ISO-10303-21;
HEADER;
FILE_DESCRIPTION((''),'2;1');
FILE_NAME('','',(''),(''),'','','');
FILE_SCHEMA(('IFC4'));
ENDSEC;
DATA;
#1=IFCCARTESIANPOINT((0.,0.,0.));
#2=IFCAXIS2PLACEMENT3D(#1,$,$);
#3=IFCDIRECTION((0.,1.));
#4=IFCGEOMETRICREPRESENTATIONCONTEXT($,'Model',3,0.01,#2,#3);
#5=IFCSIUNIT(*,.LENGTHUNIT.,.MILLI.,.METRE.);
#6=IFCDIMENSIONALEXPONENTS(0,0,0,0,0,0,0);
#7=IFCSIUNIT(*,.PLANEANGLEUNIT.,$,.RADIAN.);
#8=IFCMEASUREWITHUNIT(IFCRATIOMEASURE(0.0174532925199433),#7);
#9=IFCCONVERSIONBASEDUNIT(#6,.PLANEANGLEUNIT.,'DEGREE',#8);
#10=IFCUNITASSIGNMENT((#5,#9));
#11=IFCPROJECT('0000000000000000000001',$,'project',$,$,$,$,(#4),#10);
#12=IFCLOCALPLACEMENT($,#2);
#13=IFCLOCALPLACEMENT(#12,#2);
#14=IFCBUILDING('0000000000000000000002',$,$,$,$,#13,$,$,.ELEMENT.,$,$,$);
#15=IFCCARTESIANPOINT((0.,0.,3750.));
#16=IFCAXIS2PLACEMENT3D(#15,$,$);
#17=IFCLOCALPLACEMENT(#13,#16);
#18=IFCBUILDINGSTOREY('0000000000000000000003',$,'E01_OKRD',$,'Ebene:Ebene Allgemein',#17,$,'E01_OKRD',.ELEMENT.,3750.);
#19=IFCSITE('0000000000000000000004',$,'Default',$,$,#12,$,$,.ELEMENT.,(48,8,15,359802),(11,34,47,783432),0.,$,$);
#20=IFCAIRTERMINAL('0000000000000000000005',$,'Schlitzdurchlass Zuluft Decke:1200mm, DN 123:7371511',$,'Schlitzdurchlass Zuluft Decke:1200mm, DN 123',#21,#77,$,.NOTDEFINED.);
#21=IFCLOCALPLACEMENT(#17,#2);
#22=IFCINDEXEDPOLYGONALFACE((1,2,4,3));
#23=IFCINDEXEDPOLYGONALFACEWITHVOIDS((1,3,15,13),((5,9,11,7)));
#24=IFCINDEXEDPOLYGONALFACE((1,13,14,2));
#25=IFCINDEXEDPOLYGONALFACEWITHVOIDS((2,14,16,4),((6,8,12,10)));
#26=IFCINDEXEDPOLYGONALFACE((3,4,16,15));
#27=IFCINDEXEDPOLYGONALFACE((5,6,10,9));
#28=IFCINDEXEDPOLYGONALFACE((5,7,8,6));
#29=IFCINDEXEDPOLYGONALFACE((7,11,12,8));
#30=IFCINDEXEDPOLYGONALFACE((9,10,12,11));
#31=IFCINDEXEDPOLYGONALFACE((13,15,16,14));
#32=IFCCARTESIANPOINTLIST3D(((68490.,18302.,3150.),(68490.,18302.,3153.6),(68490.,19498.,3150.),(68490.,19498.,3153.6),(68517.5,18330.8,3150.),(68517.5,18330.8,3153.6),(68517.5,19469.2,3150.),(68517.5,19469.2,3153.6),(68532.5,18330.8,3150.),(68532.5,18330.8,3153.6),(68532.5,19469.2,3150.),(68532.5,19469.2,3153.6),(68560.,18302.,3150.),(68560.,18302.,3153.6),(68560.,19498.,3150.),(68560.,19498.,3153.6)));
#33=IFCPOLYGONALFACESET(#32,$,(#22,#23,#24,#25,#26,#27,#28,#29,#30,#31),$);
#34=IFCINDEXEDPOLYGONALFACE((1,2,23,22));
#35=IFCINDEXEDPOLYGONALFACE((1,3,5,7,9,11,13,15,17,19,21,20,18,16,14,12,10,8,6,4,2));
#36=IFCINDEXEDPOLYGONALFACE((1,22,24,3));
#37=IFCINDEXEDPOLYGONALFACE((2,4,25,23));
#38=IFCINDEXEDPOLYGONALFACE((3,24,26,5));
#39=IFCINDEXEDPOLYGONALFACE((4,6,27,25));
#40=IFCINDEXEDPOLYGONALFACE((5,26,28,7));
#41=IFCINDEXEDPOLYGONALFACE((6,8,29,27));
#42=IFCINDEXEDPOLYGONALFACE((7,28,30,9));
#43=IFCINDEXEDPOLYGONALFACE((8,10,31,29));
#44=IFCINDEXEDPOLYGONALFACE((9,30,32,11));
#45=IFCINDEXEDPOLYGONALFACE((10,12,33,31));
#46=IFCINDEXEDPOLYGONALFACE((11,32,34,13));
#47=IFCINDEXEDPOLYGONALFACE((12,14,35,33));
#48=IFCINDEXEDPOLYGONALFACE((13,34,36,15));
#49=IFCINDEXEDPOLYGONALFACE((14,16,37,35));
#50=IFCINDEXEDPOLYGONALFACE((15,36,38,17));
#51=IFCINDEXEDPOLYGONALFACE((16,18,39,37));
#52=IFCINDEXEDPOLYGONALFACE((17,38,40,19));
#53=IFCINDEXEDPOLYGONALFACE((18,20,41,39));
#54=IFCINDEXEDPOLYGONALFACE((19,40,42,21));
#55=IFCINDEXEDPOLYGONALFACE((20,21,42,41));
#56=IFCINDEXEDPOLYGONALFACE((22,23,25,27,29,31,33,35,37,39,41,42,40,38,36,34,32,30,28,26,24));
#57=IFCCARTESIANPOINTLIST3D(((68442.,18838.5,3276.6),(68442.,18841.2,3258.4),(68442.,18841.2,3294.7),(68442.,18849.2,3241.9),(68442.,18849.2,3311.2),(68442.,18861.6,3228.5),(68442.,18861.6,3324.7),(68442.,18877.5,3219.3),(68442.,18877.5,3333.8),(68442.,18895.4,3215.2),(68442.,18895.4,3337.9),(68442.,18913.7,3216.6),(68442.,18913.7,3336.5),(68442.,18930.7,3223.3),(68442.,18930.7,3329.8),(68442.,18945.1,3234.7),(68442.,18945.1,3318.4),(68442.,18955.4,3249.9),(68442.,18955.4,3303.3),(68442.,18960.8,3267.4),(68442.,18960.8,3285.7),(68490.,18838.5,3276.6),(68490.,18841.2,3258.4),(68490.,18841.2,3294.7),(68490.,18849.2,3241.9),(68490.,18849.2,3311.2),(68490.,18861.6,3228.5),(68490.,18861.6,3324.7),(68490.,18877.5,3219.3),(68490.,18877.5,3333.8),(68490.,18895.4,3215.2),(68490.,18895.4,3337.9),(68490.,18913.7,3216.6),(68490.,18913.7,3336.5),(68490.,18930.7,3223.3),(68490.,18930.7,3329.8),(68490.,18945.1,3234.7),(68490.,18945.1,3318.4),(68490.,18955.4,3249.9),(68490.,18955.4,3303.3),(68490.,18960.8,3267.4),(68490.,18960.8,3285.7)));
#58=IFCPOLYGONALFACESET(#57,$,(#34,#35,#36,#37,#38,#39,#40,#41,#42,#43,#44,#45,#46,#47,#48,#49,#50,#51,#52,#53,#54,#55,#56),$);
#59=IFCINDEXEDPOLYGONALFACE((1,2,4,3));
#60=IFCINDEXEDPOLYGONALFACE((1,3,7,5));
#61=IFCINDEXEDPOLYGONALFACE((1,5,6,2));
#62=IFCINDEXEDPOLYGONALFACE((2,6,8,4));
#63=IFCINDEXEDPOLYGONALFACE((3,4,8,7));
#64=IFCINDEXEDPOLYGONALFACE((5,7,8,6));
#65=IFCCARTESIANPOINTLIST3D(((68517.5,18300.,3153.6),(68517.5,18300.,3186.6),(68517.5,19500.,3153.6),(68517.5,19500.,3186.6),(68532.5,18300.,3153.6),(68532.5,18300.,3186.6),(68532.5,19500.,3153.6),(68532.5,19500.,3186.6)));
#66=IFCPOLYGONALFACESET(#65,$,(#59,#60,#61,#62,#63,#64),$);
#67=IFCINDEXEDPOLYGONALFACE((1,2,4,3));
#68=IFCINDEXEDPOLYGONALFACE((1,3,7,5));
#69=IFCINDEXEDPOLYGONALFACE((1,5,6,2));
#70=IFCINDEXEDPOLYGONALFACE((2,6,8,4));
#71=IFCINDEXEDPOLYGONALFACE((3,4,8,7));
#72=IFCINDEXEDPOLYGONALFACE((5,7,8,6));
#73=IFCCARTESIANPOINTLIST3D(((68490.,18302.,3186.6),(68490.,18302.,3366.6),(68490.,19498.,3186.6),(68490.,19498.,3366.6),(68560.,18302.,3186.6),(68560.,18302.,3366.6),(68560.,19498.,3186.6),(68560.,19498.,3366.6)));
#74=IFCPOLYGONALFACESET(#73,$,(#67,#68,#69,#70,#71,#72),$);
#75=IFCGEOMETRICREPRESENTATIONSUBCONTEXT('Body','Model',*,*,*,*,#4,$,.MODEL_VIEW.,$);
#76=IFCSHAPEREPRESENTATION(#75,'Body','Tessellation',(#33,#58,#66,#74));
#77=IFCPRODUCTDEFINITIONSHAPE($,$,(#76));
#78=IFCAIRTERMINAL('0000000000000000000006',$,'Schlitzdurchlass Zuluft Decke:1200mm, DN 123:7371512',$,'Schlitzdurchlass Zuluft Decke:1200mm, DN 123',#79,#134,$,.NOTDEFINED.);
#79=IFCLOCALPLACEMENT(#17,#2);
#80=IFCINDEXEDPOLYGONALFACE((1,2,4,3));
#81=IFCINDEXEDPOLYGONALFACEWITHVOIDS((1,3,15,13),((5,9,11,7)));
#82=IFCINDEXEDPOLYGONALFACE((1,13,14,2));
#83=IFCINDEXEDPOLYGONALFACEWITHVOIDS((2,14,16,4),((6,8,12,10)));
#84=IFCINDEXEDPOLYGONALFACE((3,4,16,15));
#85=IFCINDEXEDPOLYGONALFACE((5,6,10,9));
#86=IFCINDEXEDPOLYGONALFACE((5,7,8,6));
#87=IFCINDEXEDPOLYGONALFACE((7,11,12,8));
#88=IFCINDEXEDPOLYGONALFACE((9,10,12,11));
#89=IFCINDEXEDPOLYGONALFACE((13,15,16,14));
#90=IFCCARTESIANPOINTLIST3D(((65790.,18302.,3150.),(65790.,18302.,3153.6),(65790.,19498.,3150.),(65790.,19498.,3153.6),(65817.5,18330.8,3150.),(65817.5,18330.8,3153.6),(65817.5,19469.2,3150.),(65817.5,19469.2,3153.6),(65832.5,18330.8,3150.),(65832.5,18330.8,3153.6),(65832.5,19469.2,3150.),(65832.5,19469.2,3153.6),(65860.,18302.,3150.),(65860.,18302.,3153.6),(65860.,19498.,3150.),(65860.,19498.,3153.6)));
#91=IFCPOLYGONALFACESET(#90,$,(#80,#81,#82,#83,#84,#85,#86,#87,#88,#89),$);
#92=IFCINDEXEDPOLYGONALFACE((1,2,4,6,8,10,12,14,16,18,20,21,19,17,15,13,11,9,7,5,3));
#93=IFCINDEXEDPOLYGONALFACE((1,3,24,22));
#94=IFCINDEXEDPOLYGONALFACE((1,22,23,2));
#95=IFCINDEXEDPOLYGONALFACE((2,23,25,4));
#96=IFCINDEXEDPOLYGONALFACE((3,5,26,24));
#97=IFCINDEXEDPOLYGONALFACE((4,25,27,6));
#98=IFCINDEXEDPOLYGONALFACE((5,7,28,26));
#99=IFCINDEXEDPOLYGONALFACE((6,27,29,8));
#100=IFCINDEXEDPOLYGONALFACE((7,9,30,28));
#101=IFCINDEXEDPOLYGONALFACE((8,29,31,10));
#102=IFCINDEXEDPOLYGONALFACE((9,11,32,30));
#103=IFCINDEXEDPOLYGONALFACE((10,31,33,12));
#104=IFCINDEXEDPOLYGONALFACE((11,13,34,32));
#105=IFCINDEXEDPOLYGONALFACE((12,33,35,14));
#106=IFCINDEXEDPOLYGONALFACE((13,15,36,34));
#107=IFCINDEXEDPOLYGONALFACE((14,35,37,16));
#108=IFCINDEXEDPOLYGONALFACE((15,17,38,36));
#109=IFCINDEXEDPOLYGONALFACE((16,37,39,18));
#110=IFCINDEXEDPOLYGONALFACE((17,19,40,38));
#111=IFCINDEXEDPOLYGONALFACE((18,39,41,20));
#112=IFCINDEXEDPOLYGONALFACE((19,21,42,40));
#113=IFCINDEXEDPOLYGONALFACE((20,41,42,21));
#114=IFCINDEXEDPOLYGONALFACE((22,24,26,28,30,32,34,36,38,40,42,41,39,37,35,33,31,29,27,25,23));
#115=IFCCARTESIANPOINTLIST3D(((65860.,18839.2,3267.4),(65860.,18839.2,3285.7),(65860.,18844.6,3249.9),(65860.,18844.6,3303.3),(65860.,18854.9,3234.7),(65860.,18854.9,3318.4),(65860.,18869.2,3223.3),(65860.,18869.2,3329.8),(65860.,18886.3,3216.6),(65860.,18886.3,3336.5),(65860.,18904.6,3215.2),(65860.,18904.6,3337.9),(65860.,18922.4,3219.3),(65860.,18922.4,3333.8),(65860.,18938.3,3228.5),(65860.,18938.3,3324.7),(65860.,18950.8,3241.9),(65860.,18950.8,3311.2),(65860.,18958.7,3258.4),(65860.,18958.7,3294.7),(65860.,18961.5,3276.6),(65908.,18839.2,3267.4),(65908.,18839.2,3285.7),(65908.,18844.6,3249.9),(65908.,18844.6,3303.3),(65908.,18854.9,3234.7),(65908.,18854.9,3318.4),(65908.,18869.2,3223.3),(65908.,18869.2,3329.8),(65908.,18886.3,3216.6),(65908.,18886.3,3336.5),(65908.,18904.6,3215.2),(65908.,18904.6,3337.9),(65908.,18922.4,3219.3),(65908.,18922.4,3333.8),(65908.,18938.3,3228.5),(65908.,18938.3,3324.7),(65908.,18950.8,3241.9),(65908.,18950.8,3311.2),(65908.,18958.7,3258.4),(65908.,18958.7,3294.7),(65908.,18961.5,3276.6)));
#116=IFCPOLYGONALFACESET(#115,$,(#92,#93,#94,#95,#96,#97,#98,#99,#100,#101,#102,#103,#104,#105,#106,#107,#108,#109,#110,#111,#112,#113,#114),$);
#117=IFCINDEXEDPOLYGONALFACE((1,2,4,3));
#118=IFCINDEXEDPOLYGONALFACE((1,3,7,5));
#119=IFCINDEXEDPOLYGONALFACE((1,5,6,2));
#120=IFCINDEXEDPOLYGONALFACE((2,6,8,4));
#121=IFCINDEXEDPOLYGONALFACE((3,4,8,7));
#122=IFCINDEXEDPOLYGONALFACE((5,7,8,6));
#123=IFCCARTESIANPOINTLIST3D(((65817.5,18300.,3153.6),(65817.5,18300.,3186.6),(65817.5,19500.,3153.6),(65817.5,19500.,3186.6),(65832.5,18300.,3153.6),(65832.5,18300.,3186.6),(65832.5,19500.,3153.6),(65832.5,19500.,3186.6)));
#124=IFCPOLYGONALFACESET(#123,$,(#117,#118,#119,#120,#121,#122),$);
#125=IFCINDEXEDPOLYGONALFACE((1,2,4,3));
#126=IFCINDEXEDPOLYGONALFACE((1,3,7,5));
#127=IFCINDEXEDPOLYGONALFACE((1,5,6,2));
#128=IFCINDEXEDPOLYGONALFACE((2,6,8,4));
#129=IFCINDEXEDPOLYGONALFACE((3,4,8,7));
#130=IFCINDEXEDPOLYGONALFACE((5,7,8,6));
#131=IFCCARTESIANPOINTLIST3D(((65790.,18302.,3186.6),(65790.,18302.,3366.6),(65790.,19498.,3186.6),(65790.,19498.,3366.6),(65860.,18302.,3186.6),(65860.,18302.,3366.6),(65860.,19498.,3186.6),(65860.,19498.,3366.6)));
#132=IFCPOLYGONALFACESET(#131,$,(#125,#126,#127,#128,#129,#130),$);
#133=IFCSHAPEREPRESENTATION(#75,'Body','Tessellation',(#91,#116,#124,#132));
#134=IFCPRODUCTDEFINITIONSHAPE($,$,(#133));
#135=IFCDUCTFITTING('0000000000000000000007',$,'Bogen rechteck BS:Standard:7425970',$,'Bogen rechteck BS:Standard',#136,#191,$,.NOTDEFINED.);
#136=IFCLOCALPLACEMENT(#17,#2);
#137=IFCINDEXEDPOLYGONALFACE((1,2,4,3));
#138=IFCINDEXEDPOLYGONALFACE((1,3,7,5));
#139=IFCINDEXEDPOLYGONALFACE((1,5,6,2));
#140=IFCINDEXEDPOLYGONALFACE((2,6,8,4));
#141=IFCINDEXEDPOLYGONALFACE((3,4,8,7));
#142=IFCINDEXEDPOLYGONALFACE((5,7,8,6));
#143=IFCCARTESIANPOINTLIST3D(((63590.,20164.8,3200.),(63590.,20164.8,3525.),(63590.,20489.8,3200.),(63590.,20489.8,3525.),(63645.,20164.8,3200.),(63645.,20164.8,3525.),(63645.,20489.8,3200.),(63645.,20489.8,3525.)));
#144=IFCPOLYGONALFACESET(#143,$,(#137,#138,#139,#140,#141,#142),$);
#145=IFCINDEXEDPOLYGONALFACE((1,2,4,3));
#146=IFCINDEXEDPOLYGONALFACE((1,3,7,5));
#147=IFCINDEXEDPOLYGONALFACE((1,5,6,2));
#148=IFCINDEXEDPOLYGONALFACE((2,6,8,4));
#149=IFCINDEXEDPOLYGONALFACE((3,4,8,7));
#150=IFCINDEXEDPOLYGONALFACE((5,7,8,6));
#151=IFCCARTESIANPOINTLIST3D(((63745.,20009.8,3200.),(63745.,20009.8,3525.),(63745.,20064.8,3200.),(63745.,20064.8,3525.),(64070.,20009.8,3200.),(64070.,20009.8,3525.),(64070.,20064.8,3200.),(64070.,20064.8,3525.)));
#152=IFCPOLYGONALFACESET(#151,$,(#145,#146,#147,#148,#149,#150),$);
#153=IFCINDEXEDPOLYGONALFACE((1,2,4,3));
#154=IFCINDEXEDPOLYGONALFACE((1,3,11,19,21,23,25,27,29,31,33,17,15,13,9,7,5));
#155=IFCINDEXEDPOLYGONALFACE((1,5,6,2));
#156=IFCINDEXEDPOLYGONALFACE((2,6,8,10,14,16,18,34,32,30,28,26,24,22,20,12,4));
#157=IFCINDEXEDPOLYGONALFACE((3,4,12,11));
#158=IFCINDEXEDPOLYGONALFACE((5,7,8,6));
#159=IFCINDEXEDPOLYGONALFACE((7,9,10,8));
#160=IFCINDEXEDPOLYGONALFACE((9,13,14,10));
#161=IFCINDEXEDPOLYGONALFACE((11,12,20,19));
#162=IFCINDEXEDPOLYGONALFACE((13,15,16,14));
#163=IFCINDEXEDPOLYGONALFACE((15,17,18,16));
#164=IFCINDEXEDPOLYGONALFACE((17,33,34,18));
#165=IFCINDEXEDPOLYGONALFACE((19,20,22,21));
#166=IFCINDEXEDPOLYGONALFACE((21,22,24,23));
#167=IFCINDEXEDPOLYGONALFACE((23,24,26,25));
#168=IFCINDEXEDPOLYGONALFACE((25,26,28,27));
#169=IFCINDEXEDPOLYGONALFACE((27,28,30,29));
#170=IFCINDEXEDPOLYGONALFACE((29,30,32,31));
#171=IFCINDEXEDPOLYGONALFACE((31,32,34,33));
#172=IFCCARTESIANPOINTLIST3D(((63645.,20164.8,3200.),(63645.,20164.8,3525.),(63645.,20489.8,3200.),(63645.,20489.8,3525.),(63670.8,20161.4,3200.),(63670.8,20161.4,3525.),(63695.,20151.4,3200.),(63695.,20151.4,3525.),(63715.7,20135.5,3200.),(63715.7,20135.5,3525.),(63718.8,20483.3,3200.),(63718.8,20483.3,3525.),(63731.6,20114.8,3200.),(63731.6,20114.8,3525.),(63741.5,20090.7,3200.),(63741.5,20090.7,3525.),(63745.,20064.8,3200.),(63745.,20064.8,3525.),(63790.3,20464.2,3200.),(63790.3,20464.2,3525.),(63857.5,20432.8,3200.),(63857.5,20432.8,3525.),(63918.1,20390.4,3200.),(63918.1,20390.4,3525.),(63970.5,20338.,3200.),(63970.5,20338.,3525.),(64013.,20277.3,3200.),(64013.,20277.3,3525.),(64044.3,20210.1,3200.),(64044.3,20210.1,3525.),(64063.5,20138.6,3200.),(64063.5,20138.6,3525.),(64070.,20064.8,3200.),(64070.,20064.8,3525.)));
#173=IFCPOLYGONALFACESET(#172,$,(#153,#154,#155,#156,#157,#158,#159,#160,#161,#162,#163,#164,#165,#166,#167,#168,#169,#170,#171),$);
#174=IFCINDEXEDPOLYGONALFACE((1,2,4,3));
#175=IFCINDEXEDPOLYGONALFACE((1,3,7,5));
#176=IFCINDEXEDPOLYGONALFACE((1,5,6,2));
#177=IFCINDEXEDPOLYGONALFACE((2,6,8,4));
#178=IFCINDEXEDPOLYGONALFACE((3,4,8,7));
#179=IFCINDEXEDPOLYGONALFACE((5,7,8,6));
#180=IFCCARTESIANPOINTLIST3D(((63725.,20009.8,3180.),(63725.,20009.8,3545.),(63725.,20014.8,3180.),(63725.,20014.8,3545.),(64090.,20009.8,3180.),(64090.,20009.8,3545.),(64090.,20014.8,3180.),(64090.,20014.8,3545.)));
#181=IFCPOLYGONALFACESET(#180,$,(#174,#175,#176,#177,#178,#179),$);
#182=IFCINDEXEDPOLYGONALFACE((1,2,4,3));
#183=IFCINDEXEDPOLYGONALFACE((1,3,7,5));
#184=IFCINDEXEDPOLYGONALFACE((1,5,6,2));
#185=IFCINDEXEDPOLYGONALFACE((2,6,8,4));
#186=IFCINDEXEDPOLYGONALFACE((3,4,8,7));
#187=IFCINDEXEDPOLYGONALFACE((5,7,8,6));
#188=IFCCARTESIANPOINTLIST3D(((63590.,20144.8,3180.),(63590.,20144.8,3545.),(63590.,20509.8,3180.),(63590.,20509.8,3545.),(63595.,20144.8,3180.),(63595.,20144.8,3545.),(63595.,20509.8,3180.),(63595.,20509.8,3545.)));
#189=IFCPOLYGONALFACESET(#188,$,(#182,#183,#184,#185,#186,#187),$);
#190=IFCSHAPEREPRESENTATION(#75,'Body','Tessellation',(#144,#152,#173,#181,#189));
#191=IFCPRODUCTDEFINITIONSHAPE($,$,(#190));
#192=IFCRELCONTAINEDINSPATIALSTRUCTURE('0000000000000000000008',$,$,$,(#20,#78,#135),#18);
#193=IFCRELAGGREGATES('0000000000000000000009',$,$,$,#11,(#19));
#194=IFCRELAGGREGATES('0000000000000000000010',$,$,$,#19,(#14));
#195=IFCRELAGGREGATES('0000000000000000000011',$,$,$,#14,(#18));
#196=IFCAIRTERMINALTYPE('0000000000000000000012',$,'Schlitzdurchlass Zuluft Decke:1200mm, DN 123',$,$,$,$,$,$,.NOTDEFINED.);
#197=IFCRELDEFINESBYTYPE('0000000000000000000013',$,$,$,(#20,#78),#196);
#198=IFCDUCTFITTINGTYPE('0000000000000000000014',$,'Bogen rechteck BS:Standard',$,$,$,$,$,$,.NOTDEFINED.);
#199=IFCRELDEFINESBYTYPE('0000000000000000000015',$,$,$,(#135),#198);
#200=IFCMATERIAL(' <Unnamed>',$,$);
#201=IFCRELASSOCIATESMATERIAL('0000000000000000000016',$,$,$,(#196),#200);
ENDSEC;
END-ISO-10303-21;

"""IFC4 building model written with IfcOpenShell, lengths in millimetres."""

from ifc_helpers import new_model, entity, si_unit, converted_unit, direction, frame, frame_2d, origin, origin_2d_with_axis, place, context, subcontext, project, spatial, polyline, circle_curve, parameter, trimmed, segment, composite_curve, rectangle, circle, outline, extrude, source, transform, mapped, material, type_object, type_shapes, element, save


model = new_model("IFC4")

# Units and contexts
model_context = context("Model", 3, precision=0.01, world=origin(), true_north=direction((0.0, 1.0)))
body_context = subcontext(model_context, "Body", "Model", "MODEL_VIEW")
ifc_project = project(units=[si_unit("LENGTHUNIT", "METRE", prefix="MILLI"), converted_unit("PLANEANGLEUNIT", "DEGREE", entity("IfcRatioMeasure", 0.0174532925199433), si_unit("PLANEANGLEUNIT", "RADIAN"), dimensions=[0, 0, 0, 0, 0, 0, 0])], contexts=[model_context])

# Site, building, storey
site_placement = place(None, origin())
site = spatial("IfcSite", under=ifc_project, at=site_placement, Name="Default", CompositionType="ELEMENT", RefLatitude=(48, 8, 15, 359802), RefLongitude=(11, 34, 47, 783432), RefElevation=0.0)
building_placement = place(site_placement, origin())
building = spatial("IfcBuilding", under=site, at=building_placement, CompositionType="ELEMENT")
storey_placement = place(building_placement, frame((0.0, 0.0, 3750.0)))
storey = spatial("IfcBuildingStorey", under=building, at=storey_placement, Name="E01_OKRD", ObjectType="Ebene:Ebene Allgemein", LongName="E01_OKRD", CompositionType="ELEMENT", Elevation=3750.0)

# Shared definitions
ifc_material_1 = material(Name=" <Unnamed>")

# Air terminals
air_terminal_type_1 = type_object("IfcAirTerminalType", Name="Schlitzdurchlass Zuluft Decke:1200mm, DN 123", PredefinedType="NOTDEFINED", material=ifc_material_1)
shared_shape_1 = source(origin(), body_context, "Body", "SweptSolid", [
    extrude(outline(polyline([(-598.0, -35.0), (598.0, -35.0), (598.0, 35.0), (-598.0, 35.0), (-598.0, -35.0)]), holes=[polyline([(-569.2, -7.5), (-569.2, 7.5), (569.2, 7.5), (569.2, -7.5), (-569.2, -7.5)])]), frame((600.0, 35.0, 0.0), z_axis=(0.0, 0.0, 1.0), x_axis=(-1.0, 0.0, 0.0)), (0.0, 0.0, 1.0), 3.6),
    extrude(circle(Radius=61.5, at=frame_2d((0.0, 0.0), x_axis=(1.0, 0.0))), frame((600.0, 70.0, 126.6), z_axis=(0.0, 1.0, 0.0), x_axis=(-1.0, 0.0, 0.0)), (0.0, 0.0, 1.0), 48.0),
    extrude(rectangle(XDim=1200.0, YDim=15.0, at=origin_2d_with_axis()), frame((600.0, 35.0, 3.6), z_axis=(0.0, 0.0, 1.0), x_axis=(-1.0, 0.0, 0.0)), (0.0, 0.0, 1.0), 33.0),
    extrude(rectangle(XDim=1196.0, YDim=70.0, at=origin_2d_with_axis()), frame((600.0, 35.0, 36.6), z_axis=(0.0, 0.0, 1.0), x_axis=(-1.0, 0.0, 0.0)), (0.0, 0.0, 1.0), 180.0),
])
type_shapes(air_terminal_type_1, [shared_shape_1])
for number, where, z_axis, x_axis, name in (
    (1, (68560.0, 18300.0, 3150.0), (0.0, 0.0, 1.0), (0.0, 1.0, 0.0), "Schlitzdurchlass Zuluft Decke:1200mm, DN 123:7371511"),
    (2, (65790.0, 19500.0, 3150.0), (0.0, 0.0, 1.0), (0.0, -1.0, 0.0), "Schlitzdurchlass Zuluft Decke:1200mm, DN 123:7371512"),
):
    element("IfcAirTerminal", number, at=place(storey_placement, frame(where, z_axis=z_axis, x_axis=x_axis)), inside=storey, type_object=air_terminal_type_1, Name=name, ObjectType="Schlitzdurchlass Zuluft Decke:1200mm, DN 123", PredefinedType="NOTDEFINED", context=body_context, shape_type="MappedRepresentation", body=[
        mapped(shared_shape_1, transform((0.0, 0.0, 0.0), scale=1.0)),
    ])

# Duct fitting
duct_fitting_type_1 = type_object("IfcDuctFittingType", Name="Bogen rechteck BS:Standard", PredefinedType="NOTDEFINED")
shared_shape_2 = source(origin(), body_context, "Body", "SweptSolid", [
    extrude(rectangle(XDim=55.0, YDim=325.0, at=frame_2d((0.0, 0.0), x_axis=(1.0, 0.0))), frame((0.0, 290.0, -162.5), z_axis=(0.0, 0.0, 1.0), x_axis=(0.0, 1.0, 0.0)), (0.0, 0.0, 1.0), 325.0),
    extrude(rectangle(XDim=325.0, YDim=55.0, at=frame_2d((0.0, 0.0), x_axis=(1.0, 0.0))), frame((-290.0, 0.0, -162.5), z_axis=(0.0, 0.0, 1.0), x_axis=(0.0, -1.0, 0.0)), (0.0, 0.0, 1.0), 325.0),
    extrude(outline(composite_curve([segment(polyline([(-293.8, -131.2), (31.2, -131.2)]), True, "CONTINUOUS"), segment(trimmed(circle_curve(frame_2d((131.2, -131.2), x_axis=(0.0, 1.0)), 100.0), [parameter(0.0)], [parameter(90.0)], True, "PARAMETER"), False, "CONTINUOUS"), segment(polyline([(131.2, -31.2), (131.2, 293.8)]), True, "CONTINUOUS"), segment(trimmed(circle_curve(frame_2d((131.2, -131.2), x_axis=(0.0, 1.0)), 425.0), [parameter(0.0)], [parameter(90.0)], True, "PARAMETER"), True, "CONTINUOUS")], self_intersect=False)), frame((-131.2, 131.3, -162.5), z_axis=(0.0, 0.0, 1.0), x_axis=(-1.0, 0.0, 0.0)), (0.0, 0.0, 1.0), 325.0),
    extrude(rectangle(XDim=5.0, YDim=365.0, at=frame_2d((0.0, 0.0), x_axis=(1.0, 0.0))), frame((-315.0, 0.0, -182.5)), (0.0, 0.0, 1.0), 365.0),
    extrude(rectangle(XDim=5.0, YDim=365.0, at=frame_2d((0.0, 0.0), x_axis=(1.0, 0.0))), frame((0.0, 315.0, -182.5), z_axis=(0.0, 0.0, 1.0), x_axis=(0.0, 1.0, 0.0)), (0.0, 0.0, 1.0), 365.0),
])
type_shapes(duct_fitting_type_1, [shared_shape_2])
duct_fitting_1_placement = place(storey_placement, frame((63907.5, 20327.3, 3362.5), z_axis=(0.0, 0.0, 1.0), x_axis=(0.0, 1.0, 0.0)))
element("IfcDuctFitting", 3, at=duct_fitting_1_placement, inside=storey, type_object=duct_fitting_type_1, Name="Bogen rechteck BS:Standard:7425970", ObjectType="Bogen rechteck BS:Standard", PredefinedType="NOTDEFINED", context=body_context, shape_type="MappedRepresentation", body=[
    mapped(shared_shape_2, transform((0.0, 0.0, 0.0), scale=1.0)),
])

save(model, "model.ifc")
